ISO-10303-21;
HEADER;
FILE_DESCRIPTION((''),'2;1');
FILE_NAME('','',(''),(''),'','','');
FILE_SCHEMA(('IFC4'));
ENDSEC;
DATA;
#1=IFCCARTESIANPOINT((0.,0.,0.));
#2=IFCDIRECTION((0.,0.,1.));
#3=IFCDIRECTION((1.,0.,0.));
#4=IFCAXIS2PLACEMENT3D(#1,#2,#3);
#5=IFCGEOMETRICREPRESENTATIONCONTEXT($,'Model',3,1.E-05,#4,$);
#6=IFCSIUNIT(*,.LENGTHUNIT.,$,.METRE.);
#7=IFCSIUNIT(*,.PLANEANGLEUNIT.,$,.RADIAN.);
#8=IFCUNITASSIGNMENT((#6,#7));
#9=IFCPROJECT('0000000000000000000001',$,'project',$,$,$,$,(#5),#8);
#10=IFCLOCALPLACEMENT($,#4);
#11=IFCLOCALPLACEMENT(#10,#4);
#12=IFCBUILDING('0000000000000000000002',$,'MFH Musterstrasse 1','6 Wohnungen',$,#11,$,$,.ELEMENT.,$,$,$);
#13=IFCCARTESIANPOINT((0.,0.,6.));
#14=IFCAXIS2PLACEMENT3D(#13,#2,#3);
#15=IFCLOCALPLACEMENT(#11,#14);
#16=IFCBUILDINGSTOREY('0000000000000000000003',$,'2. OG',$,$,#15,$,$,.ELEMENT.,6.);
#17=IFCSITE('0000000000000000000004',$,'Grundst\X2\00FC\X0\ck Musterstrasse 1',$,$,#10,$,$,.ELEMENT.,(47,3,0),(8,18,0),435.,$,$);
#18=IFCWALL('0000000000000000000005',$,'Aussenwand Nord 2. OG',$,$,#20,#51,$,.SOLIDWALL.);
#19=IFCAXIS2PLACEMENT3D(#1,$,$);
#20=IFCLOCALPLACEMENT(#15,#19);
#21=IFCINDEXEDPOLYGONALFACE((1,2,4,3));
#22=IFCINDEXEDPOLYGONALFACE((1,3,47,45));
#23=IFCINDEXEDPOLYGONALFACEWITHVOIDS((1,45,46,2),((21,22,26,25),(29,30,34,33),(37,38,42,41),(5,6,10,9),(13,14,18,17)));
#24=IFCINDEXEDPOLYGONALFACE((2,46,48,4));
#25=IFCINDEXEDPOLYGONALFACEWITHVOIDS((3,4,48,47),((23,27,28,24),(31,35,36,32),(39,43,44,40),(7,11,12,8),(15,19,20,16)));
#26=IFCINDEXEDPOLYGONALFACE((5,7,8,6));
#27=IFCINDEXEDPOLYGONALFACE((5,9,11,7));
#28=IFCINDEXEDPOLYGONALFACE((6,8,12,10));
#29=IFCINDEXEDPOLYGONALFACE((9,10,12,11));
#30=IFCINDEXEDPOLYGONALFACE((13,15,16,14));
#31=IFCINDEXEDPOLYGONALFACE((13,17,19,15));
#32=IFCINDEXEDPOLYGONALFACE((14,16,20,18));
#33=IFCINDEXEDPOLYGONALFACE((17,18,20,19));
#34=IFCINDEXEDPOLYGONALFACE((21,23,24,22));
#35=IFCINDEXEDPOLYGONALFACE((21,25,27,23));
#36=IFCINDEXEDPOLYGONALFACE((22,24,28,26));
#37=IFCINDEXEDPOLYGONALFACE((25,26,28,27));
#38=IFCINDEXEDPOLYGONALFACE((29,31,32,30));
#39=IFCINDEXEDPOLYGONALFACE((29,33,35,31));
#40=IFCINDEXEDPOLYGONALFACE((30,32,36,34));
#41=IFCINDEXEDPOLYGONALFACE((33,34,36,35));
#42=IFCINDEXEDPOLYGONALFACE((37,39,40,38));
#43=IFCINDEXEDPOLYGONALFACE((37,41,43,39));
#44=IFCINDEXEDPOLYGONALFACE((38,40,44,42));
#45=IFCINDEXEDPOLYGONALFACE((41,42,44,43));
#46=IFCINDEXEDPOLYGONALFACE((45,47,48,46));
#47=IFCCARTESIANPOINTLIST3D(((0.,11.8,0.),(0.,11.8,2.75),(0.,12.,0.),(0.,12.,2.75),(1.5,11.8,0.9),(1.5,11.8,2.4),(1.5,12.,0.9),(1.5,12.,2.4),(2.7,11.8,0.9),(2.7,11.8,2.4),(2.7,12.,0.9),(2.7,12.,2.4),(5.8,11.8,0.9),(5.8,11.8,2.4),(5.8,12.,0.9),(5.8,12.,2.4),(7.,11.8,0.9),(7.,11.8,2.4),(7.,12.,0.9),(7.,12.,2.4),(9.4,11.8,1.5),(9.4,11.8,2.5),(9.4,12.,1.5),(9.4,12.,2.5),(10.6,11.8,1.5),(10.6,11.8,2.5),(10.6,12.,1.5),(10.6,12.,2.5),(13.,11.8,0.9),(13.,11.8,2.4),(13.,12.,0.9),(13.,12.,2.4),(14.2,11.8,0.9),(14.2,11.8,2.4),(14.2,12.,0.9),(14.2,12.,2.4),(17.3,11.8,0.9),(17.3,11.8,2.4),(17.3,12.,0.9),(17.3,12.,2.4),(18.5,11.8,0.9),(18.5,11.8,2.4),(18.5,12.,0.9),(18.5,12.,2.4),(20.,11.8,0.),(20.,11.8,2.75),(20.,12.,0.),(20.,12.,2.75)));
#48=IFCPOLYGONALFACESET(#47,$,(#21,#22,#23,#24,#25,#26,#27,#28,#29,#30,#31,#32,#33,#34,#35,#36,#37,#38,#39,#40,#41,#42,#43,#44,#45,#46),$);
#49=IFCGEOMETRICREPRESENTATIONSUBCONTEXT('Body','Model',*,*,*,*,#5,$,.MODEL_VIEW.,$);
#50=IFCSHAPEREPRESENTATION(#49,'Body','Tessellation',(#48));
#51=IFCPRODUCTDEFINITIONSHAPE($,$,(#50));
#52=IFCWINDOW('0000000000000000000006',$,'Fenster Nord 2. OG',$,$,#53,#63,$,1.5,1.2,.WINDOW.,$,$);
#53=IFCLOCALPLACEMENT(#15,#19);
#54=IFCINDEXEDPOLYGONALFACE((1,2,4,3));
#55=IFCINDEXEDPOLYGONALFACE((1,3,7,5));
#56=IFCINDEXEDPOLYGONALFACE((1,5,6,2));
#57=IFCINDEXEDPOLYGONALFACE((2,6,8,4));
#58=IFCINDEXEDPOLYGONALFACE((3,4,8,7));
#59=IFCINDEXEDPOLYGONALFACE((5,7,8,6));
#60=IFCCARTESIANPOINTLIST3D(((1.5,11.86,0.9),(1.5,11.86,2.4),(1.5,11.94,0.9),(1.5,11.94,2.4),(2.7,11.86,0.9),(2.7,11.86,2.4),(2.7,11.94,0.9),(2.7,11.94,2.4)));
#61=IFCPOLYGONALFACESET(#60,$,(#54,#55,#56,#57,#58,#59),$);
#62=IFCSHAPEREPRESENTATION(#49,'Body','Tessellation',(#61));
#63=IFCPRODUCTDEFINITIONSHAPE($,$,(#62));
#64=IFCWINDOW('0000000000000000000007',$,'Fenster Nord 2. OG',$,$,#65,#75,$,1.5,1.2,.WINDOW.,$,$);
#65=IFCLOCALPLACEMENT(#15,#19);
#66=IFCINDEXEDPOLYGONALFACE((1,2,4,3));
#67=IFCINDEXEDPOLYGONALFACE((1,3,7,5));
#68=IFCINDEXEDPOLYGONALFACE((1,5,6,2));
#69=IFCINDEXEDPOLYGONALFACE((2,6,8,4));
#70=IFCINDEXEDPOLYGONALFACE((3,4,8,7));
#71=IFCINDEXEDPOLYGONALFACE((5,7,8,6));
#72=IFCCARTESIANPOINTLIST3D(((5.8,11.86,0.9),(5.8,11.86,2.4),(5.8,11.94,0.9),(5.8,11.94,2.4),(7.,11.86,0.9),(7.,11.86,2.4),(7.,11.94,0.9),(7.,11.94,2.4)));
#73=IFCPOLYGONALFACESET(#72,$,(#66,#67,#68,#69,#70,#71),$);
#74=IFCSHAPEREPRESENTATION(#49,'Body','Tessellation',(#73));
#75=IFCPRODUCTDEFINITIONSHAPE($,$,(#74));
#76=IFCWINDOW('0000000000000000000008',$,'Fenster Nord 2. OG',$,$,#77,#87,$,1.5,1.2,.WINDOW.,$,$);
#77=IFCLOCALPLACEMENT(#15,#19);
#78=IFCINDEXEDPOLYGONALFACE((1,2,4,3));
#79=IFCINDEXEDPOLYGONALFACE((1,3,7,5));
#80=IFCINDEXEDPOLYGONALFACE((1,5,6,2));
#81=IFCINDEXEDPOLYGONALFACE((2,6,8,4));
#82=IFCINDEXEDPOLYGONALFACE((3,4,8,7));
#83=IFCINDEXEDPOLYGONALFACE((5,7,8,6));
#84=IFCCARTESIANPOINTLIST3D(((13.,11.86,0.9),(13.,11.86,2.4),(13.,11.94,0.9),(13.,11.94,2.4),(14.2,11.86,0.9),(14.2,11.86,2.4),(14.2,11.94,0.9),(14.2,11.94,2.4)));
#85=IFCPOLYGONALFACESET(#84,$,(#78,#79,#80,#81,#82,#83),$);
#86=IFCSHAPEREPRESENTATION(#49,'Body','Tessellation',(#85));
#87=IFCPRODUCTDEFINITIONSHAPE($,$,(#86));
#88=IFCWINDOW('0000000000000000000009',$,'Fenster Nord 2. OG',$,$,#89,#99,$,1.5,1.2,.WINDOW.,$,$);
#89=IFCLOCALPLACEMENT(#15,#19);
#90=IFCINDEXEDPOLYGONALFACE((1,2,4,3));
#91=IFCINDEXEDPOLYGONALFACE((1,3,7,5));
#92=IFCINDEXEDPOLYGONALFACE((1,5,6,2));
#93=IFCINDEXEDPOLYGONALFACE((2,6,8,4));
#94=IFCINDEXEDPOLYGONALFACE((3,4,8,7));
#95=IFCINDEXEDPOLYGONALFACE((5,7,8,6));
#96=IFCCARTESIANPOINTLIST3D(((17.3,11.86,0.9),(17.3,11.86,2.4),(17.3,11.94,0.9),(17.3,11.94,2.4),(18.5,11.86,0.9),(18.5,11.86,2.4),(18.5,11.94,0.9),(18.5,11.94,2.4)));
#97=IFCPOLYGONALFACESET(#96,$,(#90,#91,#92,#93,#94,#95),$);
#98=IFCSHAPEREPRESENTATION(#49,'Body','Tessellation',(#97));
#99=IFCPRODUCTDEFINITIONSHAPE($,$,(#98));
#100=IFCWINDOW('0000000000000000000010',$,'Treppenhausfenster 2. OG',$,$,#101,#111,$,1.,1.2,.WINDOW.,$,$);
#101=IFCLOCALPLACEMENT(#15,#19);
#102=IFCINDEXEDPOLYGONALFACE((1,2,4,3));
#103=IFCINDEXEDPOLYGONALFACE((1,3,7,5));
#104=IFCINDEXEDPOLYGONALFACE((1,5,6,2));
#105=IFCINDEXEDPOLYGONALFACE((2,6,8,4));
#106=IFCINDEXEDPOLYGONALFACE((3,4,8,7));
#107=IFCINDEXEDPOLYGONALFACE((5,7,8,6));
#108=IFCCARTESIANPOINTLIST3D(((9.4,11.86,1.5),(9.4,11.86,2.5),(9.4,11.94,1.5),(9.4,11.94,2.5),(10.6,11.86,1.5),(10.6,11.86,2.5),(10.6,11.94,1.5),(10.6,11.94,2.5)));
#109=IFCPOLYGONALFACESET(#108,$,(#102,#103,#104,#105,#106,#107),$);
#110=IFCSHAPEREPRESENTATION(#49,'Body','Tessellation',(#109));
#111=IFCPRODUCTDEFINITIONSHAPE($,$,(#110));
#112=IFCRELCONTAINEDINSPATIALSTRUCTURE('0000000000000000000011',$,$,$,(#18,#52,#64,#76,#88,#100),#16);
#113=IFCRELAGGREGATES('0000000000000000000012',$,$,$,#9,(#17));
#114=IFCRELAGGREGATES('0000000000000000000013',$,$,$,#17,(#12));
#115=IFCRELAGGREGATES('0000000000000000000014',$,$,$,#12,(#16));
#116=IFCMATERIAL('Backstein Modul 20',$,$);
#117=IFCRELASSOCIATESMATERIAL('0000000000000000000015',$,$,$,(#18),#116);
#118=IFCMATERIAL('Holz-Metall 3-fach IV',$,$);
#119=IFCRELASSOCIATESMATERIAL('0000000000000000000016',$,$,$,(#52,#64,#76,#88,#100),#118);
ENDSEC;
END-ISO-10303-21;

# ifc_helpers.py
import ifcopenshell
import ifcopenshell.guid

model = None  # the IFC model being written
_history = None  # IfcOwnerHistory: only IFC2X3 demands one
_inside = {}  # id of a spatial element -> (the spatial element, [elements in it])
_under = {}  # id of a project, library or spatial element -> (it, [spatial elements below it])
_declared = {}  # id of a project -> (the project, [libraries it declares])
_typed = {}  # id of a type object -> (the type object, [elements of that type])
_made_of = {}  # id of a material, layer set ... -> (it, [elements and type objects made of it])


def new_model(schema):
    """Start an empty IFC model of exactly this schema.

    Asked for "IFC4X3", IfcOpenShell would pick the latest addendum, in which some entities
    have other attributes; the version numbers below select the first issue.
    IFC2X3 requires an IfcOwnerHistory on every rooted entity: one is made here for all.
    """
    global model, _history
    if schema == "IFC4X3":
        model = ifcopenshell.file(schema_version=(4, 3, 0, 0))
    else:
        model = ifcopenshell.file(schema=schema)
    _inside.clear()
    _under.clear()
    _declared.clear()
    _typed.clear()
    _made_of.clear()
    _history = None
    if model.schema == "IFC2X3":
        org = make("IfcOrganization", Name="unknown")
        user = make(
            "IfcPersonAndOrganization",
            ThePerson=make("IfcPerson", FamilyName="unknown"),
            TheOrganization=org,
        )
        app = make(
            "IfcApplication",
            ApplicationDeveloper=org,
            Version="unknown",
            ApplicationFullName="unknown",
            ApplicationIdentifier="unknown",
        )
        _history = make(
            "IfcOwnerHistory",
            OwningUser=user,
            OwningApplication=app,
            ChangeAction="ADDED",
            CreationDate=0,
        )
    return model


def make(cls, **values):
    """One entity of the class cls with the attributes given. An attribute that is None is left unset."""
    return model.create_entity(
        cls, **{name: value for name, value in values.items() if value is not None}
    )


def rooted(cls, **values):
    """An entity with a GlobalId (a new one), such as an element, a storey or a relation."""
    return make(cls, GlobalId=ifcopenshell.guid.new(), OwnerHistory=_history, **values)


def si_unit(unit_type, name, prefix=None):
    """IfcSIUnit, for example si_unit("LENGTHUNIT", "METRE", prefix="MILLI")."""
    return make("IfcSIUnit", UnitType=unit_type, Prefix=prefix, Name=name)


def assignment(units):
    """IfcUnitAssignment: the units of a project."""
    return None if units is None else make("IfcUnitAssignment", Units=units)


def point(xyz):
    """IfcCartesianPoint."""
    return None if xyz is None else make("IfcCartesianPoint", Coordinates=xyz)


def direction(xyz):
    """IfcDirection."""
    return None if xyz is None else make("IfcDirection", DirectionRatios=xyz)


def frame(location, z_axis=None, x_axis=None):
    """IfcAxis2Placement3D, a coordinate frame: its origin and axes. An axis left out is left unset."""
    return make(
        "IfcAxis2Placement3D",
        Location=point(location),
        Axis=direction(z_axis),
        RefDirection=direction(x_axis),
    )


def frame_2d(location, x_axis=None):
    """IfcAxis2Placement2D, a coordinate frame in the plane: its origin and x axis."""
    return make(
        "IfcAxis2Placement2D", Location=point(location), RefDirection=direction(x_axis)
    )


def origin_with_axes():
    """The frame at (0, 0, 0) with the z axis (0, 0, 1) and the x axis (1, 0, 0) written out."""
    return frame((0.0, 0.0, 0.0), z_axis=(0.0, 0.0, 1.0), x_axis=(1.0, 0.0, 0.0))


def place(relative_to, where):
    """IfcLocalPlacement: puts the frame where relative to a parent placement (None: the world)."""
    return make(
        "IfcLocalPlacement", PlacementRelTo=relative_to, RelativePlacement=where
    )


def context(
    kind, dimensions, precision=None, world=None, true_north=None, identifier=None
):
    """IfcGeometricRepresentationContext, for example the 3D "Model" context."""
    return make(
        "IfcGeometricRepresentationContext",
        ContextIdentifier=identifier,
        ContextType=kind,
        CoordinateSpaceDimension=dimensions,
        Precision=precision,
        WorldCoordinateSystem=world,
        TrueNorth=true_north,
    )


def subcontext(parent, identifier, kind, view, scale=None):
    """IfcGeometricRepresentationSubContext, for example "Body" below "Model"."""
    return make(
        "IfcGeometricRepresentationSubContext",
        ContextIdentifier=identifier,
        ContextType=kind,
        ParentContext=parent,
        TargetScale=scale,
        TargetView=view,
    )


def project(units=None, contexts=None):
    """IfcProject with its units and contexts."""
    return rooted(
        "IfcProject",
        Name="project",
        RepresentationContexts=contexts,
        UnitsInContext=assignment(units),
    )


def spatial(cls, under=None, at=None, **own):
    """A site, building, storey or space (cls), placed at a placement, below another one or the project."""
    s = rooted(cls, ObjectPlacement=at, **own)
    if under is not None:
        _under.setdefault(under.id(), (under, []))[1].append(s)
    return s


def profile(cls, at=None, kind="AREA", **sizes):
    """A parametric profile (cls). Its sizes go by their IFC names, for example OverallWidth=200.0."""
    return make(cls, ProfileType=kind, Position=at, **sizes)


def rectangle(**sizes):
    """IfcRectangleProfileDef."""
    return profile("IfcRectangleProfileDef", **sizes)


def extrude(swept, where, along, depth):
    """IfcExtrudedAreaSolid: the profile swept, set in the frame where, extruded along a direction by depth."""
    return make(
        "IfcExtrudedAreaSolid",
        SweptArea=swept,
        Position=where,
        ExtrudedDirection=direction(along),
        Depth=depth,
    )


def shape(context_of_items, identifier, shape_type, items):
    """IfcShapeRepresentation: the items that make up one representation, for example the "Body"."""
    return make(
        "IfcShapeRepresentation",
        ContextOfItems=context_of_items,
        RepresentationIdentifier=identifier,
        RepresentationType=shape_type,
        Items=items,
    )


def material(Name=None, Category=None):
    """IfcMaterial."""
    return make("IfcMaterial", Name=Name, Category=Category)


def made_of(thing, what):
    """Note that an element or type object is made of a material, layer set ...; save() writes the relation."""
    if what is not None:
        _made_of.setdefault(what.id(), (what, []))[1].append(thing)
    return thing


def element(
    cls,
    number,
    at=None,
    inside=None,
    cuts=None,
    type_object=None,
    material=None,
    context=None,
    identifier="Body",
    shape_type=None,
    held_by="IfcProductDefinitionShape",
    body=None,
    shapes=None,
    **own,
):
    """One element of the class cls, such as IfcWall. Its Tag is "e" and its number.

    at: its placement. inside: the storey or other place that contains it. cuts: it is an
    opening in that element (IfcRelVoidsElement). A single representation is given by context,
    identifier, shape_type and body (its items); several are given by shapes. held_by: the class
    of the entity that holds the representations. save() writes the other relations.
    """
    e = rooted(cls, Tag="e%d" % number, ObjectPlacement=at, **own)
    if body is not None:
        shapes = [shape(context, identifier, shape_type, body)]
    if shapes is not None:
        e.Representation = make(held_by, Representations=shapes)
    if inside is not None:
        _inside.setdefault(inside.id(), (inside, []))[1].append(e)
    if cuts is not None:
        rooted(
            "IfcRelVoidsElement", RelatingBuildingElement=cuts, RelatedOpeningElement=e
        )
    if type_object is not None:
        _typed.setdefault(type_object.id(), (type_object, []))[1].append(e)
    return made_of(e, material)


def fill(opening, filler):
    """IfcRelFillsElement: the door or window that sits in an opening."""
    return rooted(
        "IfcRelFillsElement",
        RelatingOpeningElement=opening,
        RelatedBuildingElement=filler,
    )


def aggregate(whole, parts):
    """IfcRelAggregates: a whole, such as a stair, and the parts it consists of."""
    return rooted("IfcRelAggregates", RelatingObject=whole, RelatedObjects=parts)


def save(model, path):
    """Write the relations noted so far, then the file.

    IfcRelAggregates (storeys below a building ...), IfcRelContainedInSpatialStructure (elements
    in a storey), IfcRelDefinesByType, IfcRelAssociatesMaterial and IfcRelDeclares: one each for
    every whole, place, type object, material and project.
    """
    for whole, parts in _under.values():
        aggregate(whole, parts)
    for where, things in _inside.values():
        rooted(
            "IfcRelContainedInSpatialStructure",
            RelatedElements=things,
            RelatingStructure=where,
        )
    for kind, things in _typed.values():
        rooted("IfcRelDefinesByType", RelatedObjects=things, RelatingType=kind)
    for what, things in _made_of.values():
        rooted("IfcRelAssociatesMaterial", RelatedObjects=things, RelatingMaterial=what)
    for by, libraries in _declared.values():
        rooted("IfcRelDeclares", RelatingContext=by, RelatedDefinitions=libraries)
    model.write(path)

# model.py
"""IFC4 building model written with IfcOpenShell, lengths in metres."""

from ifc_helpers import new_model, si_unit, frame, frame_2d, origin_with_axes, place, context, subcontext, project, spatial, rectangle, extrude, material, element, fill, save


model = new_model("IFC4")

# Units and contexts
model_context = context("Model", 3, precision=1e-05, world=origin_with_axes())
body_context = subcontext(model_context, "Body", "Model", "MODEL_VIEW")
ifc_project = project(units=[si_unit("LENGTHUNIT", "METRE"), si_unit("PLANEANGLEUNIT", "RADIAN")], contexts=[model_context])

# Site, building, storey
site_placement = place(None, origin_with_axes())
site = spatial("IfcSite", under=ifc_project, at=site_placement, Name="Grundstück Musterstrasse 1", CompositionType="ELEMENT", RefLatitude=(47, 3, 0), RefLongitude=(8, 18, 0), RefElevation=435.0)
building_placement = place(site_placement, origin_with_axes())
building = spatial("IfcBuilding", under=site, at=building_placement, Name="MFH Musterstrasse 1", Description="6 Wohnungen", CompositionType="ELEMENT")
storey_placement = place(building_placement, frame((0.0, 0.0, 6.0), z_axis=(0.0, 0.0, 1.0), x_axis=(1.0, 0.0, 0.0)))
storey = spatial("IfcBuildingStorey", under=building, at=storey_placement, Name="2. OG", CompositionType="ELEMENT", Elevation=6.0)

# Shared definitions
ifc_material_1 = material(Name="Backstein Modul 20")
ifc_material_2 = material(Name="Holz-Metall 3-fach IV")

# Wall, openings, windows
wall_1_placement = place(storey_placement, origin_with_axes())
wall_1 = element("IfcWall", 1, at=wall_1_placement, inside=storey, material=ifc_material_1, Name="Aussenwand Nord 2. OG", PredefinedType="SOLIDWALL", context=body_context, shape_type="SweptSolid", body=[
    extrude(rectangle(XDim=20.0, YDim=0.2, at=frame_2d((10.0, 0.1), x_axis=(1.0, 0.0))), frame((0.0, 11.8, 0.0), z_axis=(0.0, 0.0, 1.0), x_axis=(1.0, 0.0, 0.0)), (0.0, 0.0, 1.0), 2.75),
])
opening_1_placement = place(storey_placement, origin_with_axes())
element("IfcOpeningElement", 2, at=opening_1_placement, cuts=wall_1, PredefinedType="OPENING", context=body_context, shape_type="SweptSolid", body=[
    extrude(rectangle(XDim=1.2, YDim=0.3, at=frame_2d((0.6, 0.15), x_axis=(1.0, 0.0))), frame((1.5, 11.75, 0.9), z_axis=(0.0, 0.0, 1.0), x_axis=(1.0, 0.0, 0.0)), (0.0, 0.0, 1.0), 1.5),
])
opening_2_placement = place(storey_placement, origin_with_axes())
element("IfcOpeningElement", 3, at=opening_2_placement, cuts=wall_1, PredefinedType="OPENING", context=body_context, shape_type="SweptSolid", body=[
    extrude(rectangle(XDim=1.2, YDim=0.3, at=frame_2d((0.6, 0.15), x_axis=(1.0, 0.0))), frame((5.8, 11.75, 0.9), z_axis=(0.0, 0.0, 1.0), x_axis=(1.0, 0.0, 0.0)), (0.0, 0.0, 1.0), 1.5),
])
opening_3_placement = place(storey_placement, origin_with_axes())
element("IfcOpeningElement", 4, at=opening_3_placement, cuts=wall_1, PredefinedType="OPENING", context=body_context, shape_type="SweptSolid", body=[
    extrude(rectangle(XDim=1.2, YDim=0.3, at=frame_2d((0.6, 0.15), x_axis=(1.0, 0.0))), frame((13.0, 11.75, 0.9), z_axis=(0.0, 0.0, 1.0), x_axis=(1.0, 0.0, 0.0)), (0.0, 0.0, 1.0), 1.5),
])
opening_4_placement = place(storey_placement, origin_with_axes())
element("IfcOpeningElement", 5, at=opening_4_placement, cuts=wall_1, PredefinedType="OPENING", context=body_context, shape_type="SweptSolid", body=[
    extrude(rectangle(XDim=1.2, YDim=0.3, at=frame_2d((0.6, 0.15), x_axis=(1.0, 0.0))), frame((17.3, 11.75, 0.9), z_axis=(0.0, 0.0, 1.0), x_axis=(1.0, 0.0, 0.0)), (0.0, 0.0, 1.0), 1.5),
])
opening_5_placement = place(storey_placement, origin_with_axes())
element("IfcOpeningElement", 6, at=opening_5_placement, cuts=wall_1, PredefinedType="OPENING", context=body_context, shape_type="SweptSolid", body=[
    extrude(rectangle(XDim=1.2, YDim=0.3, at=frame_2d((0.6, 0.15), x_axis=(1.0, 0.0))), frame((9.4, 11.75, 1.5), z_axis=(0.0, 0.0, 1.0), x_axis=(1.0, 0.0, 0.0)), (0.0, 0.0, 1.0), 1.0),
])
opening_6_placement = place(storey_placement, origin_with_axes())
opening_6 = element("IfcOpeningElement", 7, at=opening_6_placement, cuts=wall_1, PredefinedType="OPENING", context=body_context, shape_type="SweptSolid", body=[
    extrude(rectangle(XDim=1.2, YDim=0.22, at=frame_2d((0.6, 0.11), x_axis=(1.0, 0.0))), frame((1.5, 11.79, 0.9), z_axis=(0.0, 0.0, 1.0), x_axis=(1.0, 0.0, 0.0)), (0.0, 0.0, 1.0), 1.5),
])
opening_7_placement = place(storey_placement, origin_with_axes())
opening_7 = element("IfcOpeningElement", 8, at=opening_7_placement, cuts=wall_1, PredefinedType="OPENING", context=body_context, shape_type="SweptSolid", body=[
    extrude(rectangle(XDim=1.2, YDim=0.22, at=frame_2d((0.6, 0.11), x_axis=(1.0, 0.0))), frame((5.8, 11.79, 0.9), z_axis=(0.0, 0.0, 1.0), x_axis=(1.0, 0.0, 0.0)), (0.0, 0.0, 1.0), 1.5),
])
opening_8_placement = place(storey_placement, origin_with_axes())
opening_8 = element("IfcOpeningElement", 9, at=opening_8_placement, cuts=wall_1, PredefinedType="OPENING", context=body_context, shape_type="SweptSolid", body=[
    extrude(rectangle(XDim=1.2, YDim=0.22, at=frame_2d((0.6, 0.11), x_axis=(1.0, 0.0))), frame((13.0, 11.79, 0.9), z_axis=(0.0, 0.0, 1.0), x_axis=(1.0, 0.0, 0.0)), (0.0, 0.0, 1.0), 1.5),
])
opening_9_placement = place(storey_placement, origin_with_axes())
opening_9 = element("IfcOpeningElement", 10, at=opening_9_placement, cuts=wall_1, PredefinedType="OPENING", context=body_context, shape_type="SweptSolid", body=[
    extrude(rectangle(XDim=1.2, YDim=0.22, at=frame_2d((0.6, 0.11), x_axis=(1.0, 0.0))), frame((17.3, 11.79, 0.9), z_axis=(0.0, 0.0, 1.0), x_axis=(1.0, 0.0, 0.0)), (0.0, 0.0, 1.0), 1.5),
])
opening_10_placement = place(storey_placement, origin_with_axes())
opening_10 = element("IfcOpeningElement", 11, at=opening_10_placement, cuts=wall_1, PredefinedType="OPENING", context=body_context, shape_type="SweptSolid", body=[
    extrude(rectangle(XDim=1.2, YDim=0.22, at=frame_2d((0.6, 0.11), x_axis=(1.0, 0.0))), frame((9.4, 11.79, 1.5), z_axis=(0.0, 0.0, 1.0), x_axis=(1.0, 0.0, 0.0)), (0.0, 0.0, 1.0), 1.0),
])
window_1_placement = place(storey_placement, origin_with_axes())
window_1 = element("IfcWindow", 12, at=window_1_placement, inside=storey, material=ifc_material_2, Name="Fenster Nord 2. OG", OverallHeight=1.5, OverallWidth=1.2, PredefinedType="WINDOW", context=body_context, shape_type="SweptSolid", body=[
    extrude(rectangle(XDim=1.2, YDim=0.08, at=frame_2d((0.6, 0.04), x_axis=(1.0, 0.0))), frame((1.5, 11.86, 0.9), z_axis=(0.0, 0.0, 1.0), x_axis=(1.0, 0.0, 0.0)), (0.0, 0.0, 1.0), 1.5),
])
fill(opening_6, window_1)
window_2_placement = place(storey_placement, origin_with_axes())
window_2 = element("IfcWindow", 13, at=window_2_placement, inside=storey, material=ifc_material_2, Name="Fenster Nord 2. OG", OverallHeight=1.5, OverallWidth=1.2, PredefinedType="WINDOW", context=body_context, shape_type="SweptSolid", body=[
    extrude(rectangle(XDim=1.2, YDim=0.08, at=frame_2d((0.6, 0.04), x_axis=(1.0, 0.0))), frame((5.8, 11.86, 0.9), z_axis=(0.0, 0.0, 1.0), x_axis=(1.0, 0.0, 0.0)), (0.0, 0.0, 1.0), 1.5),
])
fill(opening_7, window_2)
window_3_placement = place(storey_placement, origin_with_axes())
window_3 = element("IfcWindow", 14, at=window_3_placement, inside=storey, material=ifc_material_2, Name="Fenster Nord 2. OG", OverallHeight=1.5, OverallWidth=1.2, PredefinedType="WINDOW", context=body_context, shape_type="SweptSolid", body=[
    extrude(rectangle(XDim=1.2, YDim=0.08, at=frame_2d((0.6, 0.04), x_axis=(1.0, 0.0))), frame((13.0, 11.86, 0.9), z_axis=(0.0, 0.0, 1.0), x_axis=(1.0, 0.0, 0.0)), (0.0, 0.0, 1.0), 1.5),
])
fill(opening_8, window_3)
window_4_placement = place(storey_placement, origin_with_axes())
window_4 = element("IfcWindow", 15, at=window_4_placement, inside=storey, material=ifc_material_2, Name="Fenster Nord 2. OG", OverallHeight=1.5, OverallWidth=1.2, PredefinedType="WINDOW", context=body_context, shape_type="SweptSolid", body=[
    extrude(rectangle(XDim=1.2, YDim=0.08, at=frame_2d((0.6, 0.04), x_axis=(1.0, 0.0))), frame((17.3, 11.86, 0.9), z_axis=(0.0, 0.0, 1.0), x_axis=(1.0, 0.0, 0.0)), (0.0, 0.0, 1.0), 1.5),
])
fill(opening_9, window_4)
window_5_placement = place(storey_placement, origin_with_axes())
window_5 = element("IfcWindow", 16, at=window_5_placement, inside=storey, material=ifc_material_2, Name="Treppenhausfenster 2. OG", OverallHeight=1.0, OverallWidth=1.2, PredefinedType="WINDOW", context=body_context, shape_type="SweptSolid", body=[
    extrude(rectangle(XDim=1.2, YDim=0.08, at=frame_2d((0.6, 0.04), x_axis=(1.0, 0.0))), frame((9.4, 11.86, 1.5), z_axis=(0.0, 0.0, 1.0), x_axis=(1.0, 0.0, 0.0)), (0.0, 0.0, 1.0), 1.0),
])
fill(opening_10, window_5)

save(model, "model.ifc")
